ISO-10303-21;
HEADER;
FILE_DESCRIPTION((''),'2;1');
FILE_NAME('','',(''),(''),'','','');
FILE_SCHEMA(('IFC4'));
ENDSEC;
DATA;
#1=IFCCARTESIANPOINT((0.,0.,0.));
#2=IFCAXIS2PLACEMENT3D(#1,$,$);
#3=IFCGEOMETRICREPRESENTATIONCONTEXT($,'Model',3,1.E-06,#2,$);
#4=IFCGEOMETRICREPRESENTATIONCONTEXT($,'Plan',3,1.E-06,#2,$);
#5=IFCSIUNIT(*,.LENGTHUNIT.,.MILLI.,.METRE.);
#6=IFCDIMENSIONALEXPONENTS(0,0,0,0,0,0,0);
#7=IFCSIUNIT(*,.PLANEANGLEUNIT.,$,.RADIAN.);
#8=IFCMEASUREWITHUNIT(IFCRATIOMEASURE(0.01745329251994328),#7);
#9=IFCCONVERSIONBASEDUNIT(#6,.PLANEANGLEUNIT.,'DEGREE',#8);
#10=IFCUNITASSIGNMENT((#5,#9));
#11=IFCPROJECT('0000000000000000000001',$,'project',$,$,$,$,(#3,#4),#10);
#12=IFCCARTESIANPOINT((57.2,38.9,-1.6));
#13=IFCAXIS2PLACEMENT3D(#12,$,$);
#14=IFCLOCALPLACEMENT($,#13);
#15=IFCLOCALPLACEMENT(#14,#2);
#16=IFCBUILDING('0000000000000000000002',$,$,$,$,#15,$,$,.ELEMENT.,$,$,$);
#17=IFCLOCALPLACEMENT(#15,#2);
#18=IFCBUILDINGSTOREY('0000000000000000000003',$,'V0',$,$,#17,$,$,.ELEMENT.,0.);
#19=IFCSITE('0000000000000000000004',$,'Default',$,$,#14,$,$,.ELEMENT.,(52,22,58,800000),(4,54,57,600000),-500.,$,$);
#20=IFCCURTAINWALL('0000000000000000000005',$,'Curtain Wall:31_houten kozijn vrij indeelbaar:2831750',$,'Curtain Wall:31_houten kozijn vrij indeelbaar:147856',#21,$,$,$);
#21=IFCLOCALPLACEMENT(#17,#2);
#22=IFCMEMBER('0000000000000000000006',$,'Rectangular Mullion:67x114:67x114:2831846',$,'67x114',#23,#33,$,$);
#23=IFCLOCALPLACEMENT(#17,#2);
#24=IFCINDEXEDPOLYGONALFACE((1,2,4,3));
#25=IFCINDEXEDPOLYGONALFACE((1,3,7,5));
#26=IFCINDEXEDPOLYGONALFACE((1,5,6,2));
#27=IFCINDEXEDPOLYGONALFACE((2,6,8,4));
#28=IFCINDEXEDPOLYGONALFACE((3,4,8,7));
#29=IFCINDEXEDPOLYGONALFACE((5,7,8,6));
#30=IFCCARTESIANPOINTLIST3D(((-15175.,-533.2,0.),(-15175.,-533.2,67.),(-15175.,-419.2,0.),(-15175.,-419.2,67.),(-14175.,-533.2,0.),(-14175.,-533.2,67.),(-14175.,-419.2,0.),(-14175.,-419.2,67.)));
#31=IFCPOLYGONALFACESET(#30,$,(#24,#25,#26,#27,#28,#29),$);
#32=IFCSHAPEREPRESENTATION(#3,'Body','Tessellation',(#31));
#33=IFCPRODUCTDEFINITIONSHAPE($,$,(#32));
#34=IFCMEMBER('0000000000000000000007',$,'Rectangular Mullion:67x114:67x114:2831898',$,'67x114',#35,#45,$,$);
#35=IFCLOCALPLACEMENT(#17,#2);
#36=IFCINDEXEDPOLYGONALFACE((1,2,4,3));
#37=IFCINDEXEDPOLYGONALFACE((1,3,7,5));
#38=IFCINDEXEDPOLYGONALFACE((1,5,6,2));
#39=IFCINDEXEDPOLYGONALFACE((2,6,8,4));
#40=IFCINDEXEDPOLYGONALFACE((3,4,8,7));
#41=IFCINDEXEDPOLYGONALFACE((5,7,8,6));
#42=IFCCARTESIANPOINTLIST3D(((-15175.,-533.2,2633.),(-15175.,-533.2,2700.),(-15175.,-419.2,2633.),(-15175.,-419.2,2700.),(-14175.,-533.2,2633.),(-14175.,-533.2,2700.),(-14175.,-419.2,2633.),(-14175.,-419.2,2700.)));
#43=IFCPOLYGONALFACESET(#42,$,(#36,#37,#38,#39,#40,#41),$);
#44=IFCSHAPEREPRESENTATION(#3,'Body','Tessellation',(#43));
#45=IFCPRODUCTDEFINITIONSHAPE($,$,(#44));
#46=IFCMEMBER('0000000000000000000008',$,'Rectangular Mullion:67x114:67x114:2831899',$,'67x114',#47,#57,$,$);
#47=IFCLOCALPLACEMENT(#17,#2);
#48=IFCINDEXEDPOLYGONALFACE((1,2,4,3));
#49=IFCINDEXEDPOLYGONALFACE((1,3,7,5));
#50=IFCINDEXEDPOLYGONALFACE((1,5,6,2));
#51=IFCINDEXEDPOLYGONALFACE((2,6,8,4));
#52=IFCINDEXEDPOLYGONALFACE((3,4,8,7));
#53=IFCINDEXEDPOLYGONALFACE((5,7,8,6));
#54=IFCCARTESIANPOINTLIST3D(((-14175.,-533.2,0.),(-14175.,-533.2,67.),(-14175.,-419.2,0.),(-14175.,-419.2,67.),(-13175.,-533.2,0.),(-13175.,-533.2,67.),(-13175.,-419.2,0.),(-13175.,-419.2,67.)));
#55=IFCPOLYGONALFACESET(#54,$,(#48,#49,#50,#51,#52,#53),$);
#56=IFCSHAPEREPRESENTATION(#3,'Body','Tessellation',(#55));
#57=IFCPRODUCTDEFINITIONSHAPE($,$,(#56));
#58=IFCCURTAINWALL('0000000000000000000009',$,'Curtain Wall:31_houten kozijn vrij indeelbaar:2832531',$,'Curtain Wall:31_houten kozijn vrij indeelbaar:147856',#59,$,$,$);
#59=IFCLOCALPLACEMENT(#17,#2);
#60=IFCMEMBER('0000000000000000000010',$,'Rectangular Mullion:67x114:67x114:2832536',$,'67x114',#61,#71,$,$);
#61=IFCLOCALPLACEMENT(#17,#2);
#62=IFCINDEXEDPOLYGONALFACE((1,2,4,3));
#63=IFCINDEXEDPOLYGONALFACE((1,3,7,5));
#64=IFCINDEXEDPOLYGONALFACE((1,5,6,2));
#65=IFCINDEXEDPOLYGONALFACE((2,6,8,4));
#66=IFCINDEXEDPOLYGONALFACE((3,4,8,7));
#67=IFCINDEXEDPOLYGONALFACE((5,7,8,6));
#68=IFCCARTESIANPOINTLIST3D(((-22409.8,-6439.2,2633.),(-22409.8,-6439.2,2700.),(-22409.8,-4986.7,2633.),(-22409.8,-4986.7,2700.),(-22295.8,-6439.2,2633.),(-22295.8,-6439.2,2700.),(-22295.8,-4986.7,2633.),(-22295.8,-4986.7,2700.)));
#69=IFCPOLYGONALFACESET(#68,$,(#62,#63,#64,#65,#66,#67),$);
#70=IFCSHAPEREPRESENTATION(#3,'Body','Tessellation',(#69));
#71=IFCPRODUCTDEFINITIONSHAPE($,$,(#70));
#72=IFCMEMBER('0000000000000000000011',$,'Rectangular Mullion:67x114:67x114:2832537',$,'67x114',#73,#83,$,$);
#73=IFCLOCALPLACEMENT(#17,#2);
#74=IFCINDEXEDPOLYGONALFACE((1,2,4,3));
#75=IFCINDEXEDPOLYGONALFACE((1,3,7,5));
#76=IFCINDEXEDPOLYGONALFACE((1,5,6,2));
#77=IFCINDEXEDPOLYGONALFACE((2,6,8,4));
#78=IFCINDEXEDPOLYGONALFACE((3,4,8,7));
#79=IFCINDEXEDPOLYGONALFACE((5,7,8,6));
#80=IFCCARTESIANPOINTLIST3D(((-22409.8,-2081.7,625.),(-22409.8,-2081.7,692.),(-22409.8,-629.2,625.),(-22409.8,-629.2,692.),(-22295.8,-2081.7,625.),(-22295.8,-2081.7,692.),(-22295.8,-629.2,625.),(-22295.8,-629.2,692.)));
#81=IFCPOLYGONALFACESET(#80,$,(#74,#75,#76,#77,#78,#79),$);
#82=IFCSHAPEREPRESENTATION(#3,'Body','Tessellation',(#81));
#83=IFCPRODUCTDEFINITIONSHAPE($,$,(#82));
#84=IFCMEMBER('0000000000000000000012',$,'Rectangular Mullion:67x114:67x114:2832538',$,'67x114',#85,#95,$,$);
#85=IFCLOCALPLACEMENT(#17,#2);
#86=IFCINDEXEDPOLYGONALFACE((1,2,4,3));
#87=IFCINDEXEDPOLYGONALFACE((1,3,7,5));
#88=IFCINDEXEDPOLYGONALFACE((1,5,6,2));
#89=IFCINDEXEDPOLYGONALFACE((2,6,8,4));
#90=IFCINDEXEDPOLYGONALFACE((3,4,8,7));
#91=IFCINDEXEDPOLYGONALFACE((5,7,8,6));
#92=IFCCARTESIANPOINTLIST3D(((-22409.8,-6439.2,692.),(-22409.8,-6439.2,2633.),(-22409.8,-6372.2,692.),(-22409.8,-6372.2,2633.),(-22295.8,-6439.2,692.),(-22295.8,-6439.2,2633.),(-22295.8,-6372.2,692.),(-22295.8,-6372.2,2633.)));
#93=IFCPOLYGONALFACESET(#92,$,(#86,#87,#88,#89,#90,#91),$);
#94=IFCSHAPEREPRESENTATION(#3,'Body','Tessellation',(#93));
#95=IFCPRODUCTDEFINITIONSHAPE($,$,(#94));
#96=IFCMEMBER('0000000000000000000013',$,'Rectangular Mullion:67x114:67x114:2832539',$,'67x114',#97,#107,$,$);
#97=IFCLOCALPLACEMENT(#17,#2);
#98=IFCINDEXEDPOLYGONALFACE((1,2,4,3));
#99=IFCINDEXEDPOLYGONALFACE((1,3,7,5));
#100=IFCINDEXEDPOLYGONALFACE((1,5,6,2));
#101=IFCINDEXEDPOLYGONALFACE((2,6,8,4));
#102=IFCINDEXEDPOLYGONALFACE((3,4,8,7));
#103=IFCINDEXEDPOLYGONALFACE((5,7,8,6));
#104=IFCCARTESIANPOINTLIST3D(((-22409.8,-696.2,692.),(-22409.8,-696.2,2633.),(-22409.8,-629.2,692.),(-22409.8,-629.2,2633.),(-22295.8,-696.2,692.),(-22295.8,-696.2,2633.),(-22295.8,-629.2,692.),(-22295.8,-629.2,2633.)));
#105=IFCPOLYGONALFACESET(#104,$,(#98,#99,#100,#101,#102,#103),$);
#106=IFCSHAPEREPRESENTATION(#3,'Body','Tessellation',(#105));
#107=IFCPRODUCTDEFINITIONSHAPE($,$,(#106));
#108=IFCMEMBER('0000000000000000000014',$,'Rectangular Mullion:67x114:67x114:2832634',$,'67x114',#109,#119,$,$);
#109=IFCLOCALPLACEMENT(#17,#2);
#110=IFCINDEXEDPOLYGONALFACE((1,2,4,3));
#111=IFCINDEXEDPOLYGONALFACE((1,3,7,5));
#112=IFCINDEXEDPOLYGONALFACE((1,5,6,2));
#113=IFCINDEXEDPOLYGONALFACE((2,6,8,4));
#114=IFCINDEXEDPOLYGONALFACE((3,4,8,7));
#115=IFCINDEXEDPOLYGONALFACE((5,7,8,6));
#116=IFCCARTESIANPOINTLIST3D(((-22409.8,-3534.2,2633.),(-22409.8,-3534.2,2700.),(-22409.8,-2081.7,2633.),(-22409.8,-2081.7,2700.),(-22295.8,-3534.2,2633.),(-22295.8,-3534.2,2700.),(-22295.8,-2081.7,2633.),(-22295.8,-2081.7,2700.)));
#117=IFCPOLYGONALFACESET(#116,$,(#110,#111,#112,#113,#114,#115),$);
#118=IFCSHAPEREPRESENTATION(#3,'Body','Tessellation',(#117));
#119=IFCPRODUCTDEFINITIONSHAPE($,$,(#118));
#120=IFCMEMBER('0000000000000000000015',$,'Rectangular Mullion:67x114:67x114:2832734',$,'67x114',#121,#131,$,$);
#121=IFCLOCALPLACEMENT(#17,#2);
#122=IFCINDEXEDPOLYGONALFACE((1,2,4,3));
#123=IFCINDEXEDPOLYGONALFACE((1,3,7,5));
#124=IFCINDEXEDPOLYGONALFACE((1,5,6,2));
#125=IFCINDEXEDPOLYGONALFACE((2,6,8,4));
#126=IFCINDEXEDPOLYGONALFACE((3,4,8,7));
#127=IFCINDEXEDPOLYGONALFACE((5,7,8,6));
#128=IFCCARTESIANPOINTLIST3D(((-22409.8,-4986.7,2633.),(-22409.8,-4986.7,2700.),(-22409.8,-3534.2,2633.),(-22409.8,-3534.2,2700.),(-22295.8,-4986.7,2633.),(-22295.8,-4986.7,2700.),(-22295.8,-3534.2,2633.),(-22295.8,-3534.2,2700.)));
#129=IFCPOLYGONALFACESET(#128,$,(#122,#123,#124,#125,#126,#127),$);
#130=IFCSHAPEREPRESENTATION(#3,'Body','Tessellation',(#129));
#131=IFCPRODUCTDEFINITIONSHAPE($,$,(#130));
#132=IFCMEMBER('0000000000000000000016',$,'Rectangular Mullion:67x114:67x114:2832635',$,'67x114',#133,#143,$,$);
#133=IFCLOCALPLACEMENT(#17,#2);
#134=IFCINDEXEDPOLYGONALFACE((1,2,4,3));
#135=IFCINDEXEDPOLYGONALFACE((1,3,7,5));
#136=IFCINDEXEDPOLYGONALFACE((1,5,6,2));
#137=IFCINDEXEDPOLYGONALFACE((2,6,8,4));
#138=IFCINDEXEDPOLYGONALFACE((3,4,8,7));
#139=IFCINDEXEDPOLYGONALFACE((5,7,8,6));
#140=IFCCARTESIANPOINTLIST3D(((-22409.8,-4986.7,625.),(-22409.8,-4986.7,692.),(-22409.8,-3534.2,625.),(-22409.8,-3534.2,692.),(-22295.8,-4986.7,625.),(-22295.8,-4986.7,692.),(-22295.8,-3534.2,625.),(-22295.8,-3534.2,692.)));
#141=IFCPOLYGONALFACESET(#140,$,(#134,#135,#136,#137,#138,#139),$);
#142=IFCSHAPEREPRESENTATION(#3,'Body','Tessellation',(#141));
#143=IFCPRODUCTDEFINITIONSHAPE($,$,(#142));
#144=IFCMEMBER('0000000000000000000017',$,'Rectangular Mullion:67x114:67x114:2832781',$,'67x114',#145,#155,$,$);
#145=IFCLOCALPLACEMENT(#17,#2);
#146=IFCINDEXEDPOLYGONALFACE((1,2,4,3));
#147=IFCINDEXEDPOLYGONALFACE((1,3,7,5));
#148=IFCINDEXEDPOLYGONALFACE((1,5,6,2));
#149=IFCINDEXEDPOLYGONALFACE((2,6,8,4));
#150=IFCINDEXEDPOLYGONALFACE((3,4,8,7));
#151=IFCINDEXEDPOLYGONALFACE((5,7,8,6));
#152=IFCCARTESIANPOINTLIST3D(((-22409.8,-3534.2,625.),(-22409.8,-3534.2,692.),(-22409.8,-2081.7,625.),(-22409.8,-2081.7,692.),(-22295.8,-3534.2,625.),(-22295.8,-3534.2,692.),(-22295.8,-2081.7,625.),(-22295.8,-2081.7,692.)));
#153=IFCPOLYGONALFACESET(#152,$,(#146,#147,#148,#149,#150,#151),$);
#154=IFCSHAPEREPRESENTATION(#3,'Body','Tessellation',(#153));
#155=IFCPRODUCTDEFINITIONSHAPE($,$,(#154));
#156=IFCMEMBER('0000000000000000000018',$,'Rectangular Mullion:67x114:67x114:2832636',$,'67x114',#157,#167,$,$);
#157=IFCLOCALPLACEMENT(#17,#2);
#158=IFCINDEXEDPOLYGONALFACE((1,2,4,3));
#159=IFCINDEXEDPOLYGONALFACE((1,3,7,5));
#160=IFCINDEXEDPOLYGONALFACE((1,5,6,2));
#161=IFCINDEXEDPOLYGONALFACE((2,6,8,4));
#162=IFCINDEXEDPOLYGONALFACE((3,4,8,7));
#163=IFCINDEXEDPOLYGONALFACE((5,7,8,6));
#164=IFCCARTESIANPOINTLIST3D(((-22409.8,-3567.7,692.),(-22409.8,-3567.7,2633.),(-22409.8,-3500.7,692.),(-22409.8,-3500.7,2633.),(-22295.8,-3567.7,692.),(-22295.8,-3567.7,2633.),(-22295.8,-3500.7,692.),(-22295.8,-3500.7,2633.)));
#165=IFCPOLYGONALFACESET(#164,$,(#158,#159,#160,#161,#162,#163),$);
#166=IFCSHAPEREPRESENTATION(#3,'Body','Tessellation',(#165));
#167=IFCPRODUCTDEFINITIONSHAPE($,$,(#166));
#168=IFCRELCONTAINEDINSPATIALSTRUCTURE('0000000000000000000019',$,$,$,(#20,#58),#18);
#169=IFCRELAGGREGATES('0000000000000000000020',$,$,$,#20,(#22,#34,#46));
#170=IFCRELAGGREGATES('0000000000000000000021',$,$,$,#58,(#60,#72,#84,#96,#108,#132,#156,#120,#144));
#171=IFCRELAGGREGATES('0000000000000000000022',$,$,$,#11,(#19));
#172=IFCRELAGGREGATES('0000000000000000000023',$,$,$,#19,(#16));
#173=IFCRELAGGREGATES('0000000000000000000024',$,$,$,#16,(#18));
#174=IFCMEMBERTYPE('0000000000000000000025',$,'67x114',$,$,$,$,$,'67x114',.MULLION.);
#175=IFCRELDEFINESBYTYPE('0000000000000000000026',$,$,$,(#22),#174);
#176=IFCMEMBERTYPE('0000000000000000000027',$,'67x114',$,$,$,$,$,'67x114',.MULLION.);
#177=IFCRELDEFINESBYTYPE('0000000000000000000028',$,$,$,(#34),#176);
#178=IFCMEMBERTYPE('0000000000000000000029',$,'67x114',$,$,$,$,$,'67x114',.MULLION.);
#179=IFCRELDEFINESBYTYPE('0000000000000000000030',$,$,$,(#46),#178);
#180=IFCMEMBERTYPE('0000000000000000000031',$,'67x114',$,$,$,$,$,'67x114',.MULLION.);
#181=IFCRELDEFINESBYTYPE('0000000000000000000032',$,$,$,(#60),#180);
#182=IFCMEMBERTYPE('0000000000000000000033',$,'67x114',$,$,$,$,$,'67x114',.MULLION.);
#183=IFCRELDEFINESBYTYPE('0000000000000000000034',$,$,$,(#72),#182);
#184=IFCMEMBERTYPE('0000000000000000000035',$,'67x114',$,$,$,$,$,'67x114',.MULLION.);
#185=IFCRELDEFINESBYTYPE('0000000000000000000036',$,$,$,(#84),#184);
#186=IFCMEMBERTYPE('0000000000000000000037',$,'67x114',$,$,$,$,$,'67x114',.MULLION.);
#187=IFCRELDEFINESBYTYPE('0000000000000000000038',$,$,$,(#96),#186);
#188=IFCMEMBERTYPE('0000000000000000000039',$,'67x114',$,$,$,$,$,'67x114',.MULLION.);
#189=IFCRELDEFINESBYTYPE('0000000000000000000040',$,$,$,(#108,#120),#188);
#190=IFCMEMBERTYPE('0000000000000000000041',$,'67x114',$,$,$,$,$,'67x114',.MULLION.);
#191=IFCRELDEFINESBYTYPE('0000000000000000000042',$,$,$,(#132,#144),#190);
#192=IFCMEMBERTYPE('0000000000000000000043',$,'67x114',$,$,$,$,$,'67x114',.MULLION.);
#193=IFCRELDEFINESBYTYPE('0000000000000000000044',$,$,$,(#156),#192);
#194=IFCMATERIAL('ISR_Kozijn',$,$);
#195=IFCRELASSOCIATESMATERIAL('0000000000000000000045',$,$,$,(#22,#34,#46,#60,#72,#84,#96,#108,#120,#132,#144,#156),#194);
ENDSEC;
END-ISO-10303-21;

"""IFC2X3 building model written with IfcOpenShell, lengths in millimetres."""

from ifc_helpers import new_model, entity, si_unit, converted_unit, frame, origin, origin_2d_with_axis, place, context, project, spatial, rectangle, extrude, source, transform, mapped, material, type_object, type_shapes, element, aggregate, save


model = new_model("IFC2X3")

# Units and contexts
model_context = context("Model", 3, precision=1e-06, world=origin())
plan_context = context("Plan", 3, precision=1e-06, world=origin())
ifc_project = project(units=[si_unit("LENGTHUNIT", "METRE", prefix="MILLI"), converted_unit("PLANEANGLEUNIT", "DEGREE", entity("IfcRatioMeasure", 0.01745329251994328), si_unit("PLANEANGLEUNIT", "RADIAN"), dimensions=[0, 0, 0, 0, 0, 0, 0])], contexts=[model_context, plan_context])

# Site, building, storey
site_placement = place(None, frame((57.2, 38.9, -1.6)))
site = spatial("IfcSite", under=ifc_project, at=site_placement, Name="Default", CompositionType="ELEMENT", RefLatitude=(52, 22, 58, 800000), RefLongitude=(4, 54, 57, 600000), RefElevation=-500.0)
building_placement = place(site_placement, origin())
building = spatial("IfcBuilding", under=site, at=building_placement, CompositionType="ELEMENT")
storey_placement = place(building_placement, origin())
storey = spatial("IfcBuildingStorey", under=building, at=storey_placement, Name="V0", CompositionType="ELEMENT", Elevation=0.0)

# Curtain wall
curtain_wall_1_placement = place(storey_placement, origin())
curtain_wall_1 = element("IfcCurtainWall", 1, at=curtain_wall_1_placement, inside=storey, Name="Curtain Wall:31_houten kozijn vrij indeelbaar:2831750", ObjectType="Curtain Wall:31_houten kozijn vrij indeelbaar:147856")
ifc_material_1 = material(Name="ISR_Kozijn")
placement_1 = place(building_placement, origin())
placement_2 = place(building_placement, frame((0.0, 0.0, 625.0)))

# Members
placement_3 = place(building_placement, frame((0.0, 0.0, 2425.0)))
member_type_1 = type_object("IfcMemberType", Name="67x114", ElementType="67x114", PredefinedType="MULLION")
shared_shape_1 = source(origin(), model_context, "Body", "SweptSolid", [
    extrude(rectangle(XDim=67.0, YDim=114.0, at=origin_2d_with_axis()), frame((-33.5, 57.0, -1000.0), z_axis=(0.0, 0.0, 1.0), x_axis=(-1.0, 0.0, 0.0)), (0.0, 0.0, 1.0), 1000.0),
])
type_shapes(member_type_1, [shared_shape_1])
member_1_placement = place(placement_1, frame((-15175.0, -419.2, 0.0), z_axis=(-1.0, 0.0, 0.0), x_axis=(0.0, 0.0, -1.0)))
member_1 = element("IfcMember", 2, at=member_1_placement, type_object=member_type_1, material=ifc_material_1, Name="Rectangular Mullion:67x114:67x114:2831846", ObjectType="67x114", context=model_context, shape_type="MappedRepresentation", body=[
    mapped(shared_shape_1, transform((0.0, 0.0, 0.0), scale=1.0)),
])
member_type_2 = type_object("IfcMemberType", Name="67x114", ElementType="67x114", PredefinedType="MULLION")
shared_shape_2 = source(origin(), model_context, "Body", "SweptSolid", [
    extrude(rectangle(XDim=67.0, YDim=114.0, at=origin_2d_with_axis()), frame((-33.5, 57.0, -1000.0), z_axis=(0.0, 0.0, 1.0), x_axis=(-1.0, 0.0, 0.0)), (0.0, 0.0, 1.0), 1000.0),
])
type_shapes(member_type_2, [shared_shape_2])
member_2_placement = place(placement_3, frame((-14175.0, -419.2, 275.0), z_axis=(1.0, 0.0, 0.0), x_axis=(0.0, 0.0, 1.0)))
member_2 = element("IfcMember", 3, at=member_2_placement, type_object=member_type_2, material=ifc_material_1, Name="Rectangular Mullion:67x114:67x114:2831898", ObjectType="67x114", context=model_context, shape_type="MappedRepresentation", body=[
    mapped(shared_shape_2, transform((0.0, 0.0, 0.0), scale=1.0)),
])
member_type_3 = type_object("IfcMemberType", Name="67x114", ElementType="67x114", PredefinedType="MULLION")
shared_shape_3 = source(origin(), model_context, "Body", "SweptSolid", [
    extrude(rectangle(XDim=67.0, YDim=114.0, at=origin_2d_with_axis()), frame((-33.5, 57.0, -1000.0), z_axis=(0.0, 0.0, 1.0), x_axis=(-1.0, 0.0, 0.0)), (0.0, 0.0, 1.0), 1000.0),
])
type_shapes(member_type_3, [shared_shape_3])
member_3_placement = place(placement_1, frame((-14175.0, -419.2, 0.0), z_axis=(-1.0, 0.0, 0.0), x_axis=(0.0, 0.0, -1.0)))
member_3 = element("IfcMember", 4, at=member_3_placement, type_object=member_type_3, material=ifc_material_1, Name="Rectangular Mullion:67x114:67x114:2831899", ObjectType="67x114", context=model_context, shape_type="MappedRepresentation", body=[
    mapped(shared_shape_3, transform((0.0, 0.0, 0.0), scale=1.0)),
])

# Curtain wall, members
curtain_wall_2_placement = place(storey_placement, origin())
curtain_wall_2 = element("IfcCurtainWall", 5, at=curtain_wall_2_placement, inside=storey, Name="Curtain Wall:31_houten kozijn vrij indeelbaar:2832531", ObjectType="Curtain Wall:31_houten kozijn vrij indeelbaar:147856")
member_type_4 = type_object("IfcMemberType", Name="67x114", ElementType="67x114", PredefinedType="MULLION")
shared_shape_4 = source(origin(), model_context, "Body", "SweptSolid", [
    extrude(rectangle(XDim=67.0, YDim=114.0, at=origin_2d_with_axis()), frame((-33.5, 57.0, -1452.5), z_axis=(0.0, 0.0, 1.0), x_axis=(-1.0, 0.0, 0.0)), (0.0, 0.0, 1.0), 1452.5),
])
type_shapes(member_type_4, [shared_shape_4])
member_4_placement = place(placement_3, frame((-22295.8, -6439.2, 275.0), z_axis=(0.0, -1.0, 0.0), x_axis=(0.0, 0.0, 1.0)))
member_4 = element("IfcMember", 6, at=member_4_placement, type_object=member_type_4, material=ifc_material_1, Name="Rectangular Mullion:67x114:67x114:2832536", ObjectType="67x114", context=model_context, shape_type="MappedRepresentation", body=[
    mapped(shared_shape_4, transform((0.0, 0.0, 0.0), scale=1.0)),
])
member_type_5 = type_object("IfcMemberType", Name="67x114", ElementType="67x114", PredefinedType="MULLION")
shared_shape_5 = source(origin(), model_context, "Body", "SweptSolid", [
    extrude(rectangle(XDim=67.0, YDim=114.0, at=origin_2d_with_axis()), frame((-33.5, 57.0, -1452.5), z_axis=(0.0, 0.0, 1.0), x_axis=(-1.0, 0.0, 0.0)), (0.0, 0.0, 1.0), 1452.5),
])
type_shapes(member_type_5, [shared_shape_5])
member_5_placement = place(placement_2, frame((-22295.8, -629.2, 0.0), z_axis=(0.0, 1.0, 0.0), x_axis=(0.0, 0.0, -1.0)))
member_5 = element("IfcMember", 7, at=member_5_placement, type_object=member_type_5, material=ifc_material_1, Name="Rectangular Mullion:67x114:67x114:2832537", ObjectType="67x114", context=model_context, shape_type="MappedRepresentation", body=[
    mapped(shared_shape_5, transform((0.0, 0.0, 0.0), scale=1.0)),
])
member_type_6 = type_object("IfcMemberType", Name="67x114", ElementType="67x114", PredefinedType="MULLION")
shared_shape_6 = source(origin(), model_context, "Body", "SweptSolid", [
    extrude(rectangle(XDim=67.0, YDim=114.0, at=origin_2d_with_axis()), frame((-33.5, 57.0, -1941.0), z_axis=(0.0, 0.0, 1.0), x_axis=(-1.0, 0.0, 0.0)), (0.0, 0.0, 1.0), 1941.0),
])
type_shapes(member_type_6, [shared_shape_6])
member_6_placement = place(placement_2, frame((-22295.8, -6439.2, 67.0), z_axis=(0.0, 0.0, -1.0), x_axis=(0.0, -1.0, 0.0)))
member_6 = element("IfcMember", 8, at=member_6_placement, type_object=member_type_6, material=ifc_material_1, Name="Rectangular Mullion:67x114:67x114:2832538", ObjectType="67x114", context=model_context, shape_type="MappedRepresentation", body=[
    mapped(shared_shape_6, transform((0.0, 0.0, 0.0), scale=1.0)),
])
member_type_7 = type_object("IfcMemberType", Name="67x114", ElementType="67x114", PredefinedType="MULLION")
shared_shape_7 = source(origin(), model_context, "Body", "SweptSolid", [
    extrude(rectangle(XDim=67.0, YDim=114.0, at=origin_2d_with_axis()), frame((-33.5, 57.0, -1941.0), z_axis=(0.0, 0.0, 1.0), x_axis=(-1.0, 0.0, 0.0)), (0.0, 0.0, 1.0), 1941.0),
])
type_shapes(member_type_7, [shared_shape_7])
member_7_placement = place(placement_2, frame((-22295.8, -629.2, 2008.0), z_axis=(0.0, 0.0, 1.0), x_axis=(0.0, 1.0, 0.0)))
member_7 = element("IfcMember", 9, at=member_7_placement, type_object=member_type_7, material=ifc_material_1, Name="Rectangular Mullion:67x114:67x114:2832539", ObjectType="67x114", context=model_context, shape_type="MappedRepresentation", body=[
    mapped(shared_shape_7, transform((0.0, 0.0, 0.0), scale=1.0)),
])
member_type_8 = type_object("IfcMemberType", Name="67x114", ElementType="67x114", PredefinedType="MULLION")
shared_shape_8 = source(origin(), model_context, "Body", "SweptSolid", [
    extrude(rectangle(XDim=67.0, YDim=114.0, at=origin_2d_with_axis()), frame((-33.5, 57.0, -1452.5), z_axis=(0.0, 0.0, 1.0), x_axis=(-1.0, 0.0, 0.0)), (0.0, 0.0, 1.0), 1452.5),
])
type_shapes(member_type_8, [shared_shape_8])
member_8_placement = place(placement_3, frame((-22295.8, -3534.2, 275.0), z_axis=(0.0, -1.0, 0.0), x_axis=(0.0, 0.0, 1.0)))
member_8 = element("IfcMember", 10, at=member_8_placement, type_object=member_type_8, material=ifc_material_1, Name="Rectangular Mullion:67x114:67x114:2832634", ObjectType="67x114", context=model_context, shape_type="MappedRepresentation", body=[
    mapped(shared_shape_8, transform((0.0, 0.0, 0.0), scale=1.0)),
])
member_9_placement = place(placement_3, frame((-22295.8, -4986.7, 275.0), z_axis=(0.0, -1.0, 0.0), x_axis=(0.0, 0.0, 1.0)))
member_9 = element("IfcMember", 11, at=member_9_placement, type_object=member_type_8, material=ifc_material_1, Name="Rectangular Mullion:67x114:67x114:2832734", ObjectType="67x114", context=model_context, shape_type="MappedRepresentation", body=[
    mapped(shared_shape_8, transform((0.0, 0.0, 0.0), scale=1.0)),
])
member_type_9 = type_object("IfcMemberType", Name="67x114", ElementType="67x114", PredefinedType="MULLION")
shared_shape_9 = source(origin(), model_context, "Body", "SweptSolid", [
    extrude(rectangle(XDim=67.0, YDim=114.0, at=origin_2d_with_axis()), frame((-33.5, 57.0, -1452.5), z_axis=(0.0, 0.0, 1.0), x_axis=(-1.0, 0.0, 0.0)), (0.0, 0.0, 1.0), 1452.5),
])
type_shapes(member_type_9, [shared_shape_9])
member_10_placement = place(placement_2, frame((-22295.8, -3534.2, 0.0), z_axis=(0.0, 1.0, 0.0), x_axis=(0.0, 0.0, -1.0)))
member_10 = element("IfcMember", 12, at=member_10_placement, type_object=member_type_9, material=ifc_material_1, Name="Rectangular Mullion:67x114:67x114:2832635", ObjectType="67x114", context=model_context, shape_type="MappedRepresentation", body=[
    mapped(shared_shape_9, transform((0.0, 0.0, 0.0), scale=1.0)),
])
member_11_placement = place(placement_2, frame((-22295.8, -2081.7, 0.0), z_axis=(0.0, 1.0, 0.0), x_axis=(0.0, 0.0, -1.0)))
member_11 = element("IfcMember", 13, at=member_11_placement, type_object=member_type_9, material=ifc_material_1, Name="Rectangular Mullion:67x114:67x114:2832781", ObjectType="67x114", context=model_context, shape_type="MappedRepresentation", body=[
    mapped(shared_shape_9, transform((0.0, 0.0, 0.0), scale=1.0)),
])
member_type_10 = type_object("IfcMemberType", Name="67x114", ElementType="67x114", PredefinedType="MULLION")
shared_shape_10 = source(origin(), model_context, "Body", "SweptSolid", [
    extrude(rectangle(XDim=67.0, YDim=114.0, at=origin_2d_with_axis()), frame((0.0, 57.0, -1941.0), z_axis=(0.0, 0.0, 1.0), x_axis=(-1.0, 0.0, 0.0)), (0.0, 0.0, 1.0), 1941.0),
])
type_shapes(member_type_10, [shared_shape_10])
member_12_placement = place(placement_2, frame((-22295.8, -3534.2, 67.0), z_axis=(0.0, 0.0, -1.0), x_axis=(0.0, -1.0, 0.0)))
member_12 = element("IfcMember", 14, at=member_12_placement, type_object=member_type_10, material=ifc_material_1, Name="Rectangular Mullion:67x114:67x114:2832636", ObjectType="67x114", context=model_context, shape_type="MappedRepresentation", body=[
    mapped(shared_shape_10, transform((0.0, 0.0, 0.0), scale=1.0)),
])

aggregate(curtain_wall_1, [member_1, member_2, member_3])
aggregate(curtain_wall_2, [member_4, member_5, member_6, member_7, member_8, member_10, member_12, member_9, member_11])

save(model, "model.ifc")
